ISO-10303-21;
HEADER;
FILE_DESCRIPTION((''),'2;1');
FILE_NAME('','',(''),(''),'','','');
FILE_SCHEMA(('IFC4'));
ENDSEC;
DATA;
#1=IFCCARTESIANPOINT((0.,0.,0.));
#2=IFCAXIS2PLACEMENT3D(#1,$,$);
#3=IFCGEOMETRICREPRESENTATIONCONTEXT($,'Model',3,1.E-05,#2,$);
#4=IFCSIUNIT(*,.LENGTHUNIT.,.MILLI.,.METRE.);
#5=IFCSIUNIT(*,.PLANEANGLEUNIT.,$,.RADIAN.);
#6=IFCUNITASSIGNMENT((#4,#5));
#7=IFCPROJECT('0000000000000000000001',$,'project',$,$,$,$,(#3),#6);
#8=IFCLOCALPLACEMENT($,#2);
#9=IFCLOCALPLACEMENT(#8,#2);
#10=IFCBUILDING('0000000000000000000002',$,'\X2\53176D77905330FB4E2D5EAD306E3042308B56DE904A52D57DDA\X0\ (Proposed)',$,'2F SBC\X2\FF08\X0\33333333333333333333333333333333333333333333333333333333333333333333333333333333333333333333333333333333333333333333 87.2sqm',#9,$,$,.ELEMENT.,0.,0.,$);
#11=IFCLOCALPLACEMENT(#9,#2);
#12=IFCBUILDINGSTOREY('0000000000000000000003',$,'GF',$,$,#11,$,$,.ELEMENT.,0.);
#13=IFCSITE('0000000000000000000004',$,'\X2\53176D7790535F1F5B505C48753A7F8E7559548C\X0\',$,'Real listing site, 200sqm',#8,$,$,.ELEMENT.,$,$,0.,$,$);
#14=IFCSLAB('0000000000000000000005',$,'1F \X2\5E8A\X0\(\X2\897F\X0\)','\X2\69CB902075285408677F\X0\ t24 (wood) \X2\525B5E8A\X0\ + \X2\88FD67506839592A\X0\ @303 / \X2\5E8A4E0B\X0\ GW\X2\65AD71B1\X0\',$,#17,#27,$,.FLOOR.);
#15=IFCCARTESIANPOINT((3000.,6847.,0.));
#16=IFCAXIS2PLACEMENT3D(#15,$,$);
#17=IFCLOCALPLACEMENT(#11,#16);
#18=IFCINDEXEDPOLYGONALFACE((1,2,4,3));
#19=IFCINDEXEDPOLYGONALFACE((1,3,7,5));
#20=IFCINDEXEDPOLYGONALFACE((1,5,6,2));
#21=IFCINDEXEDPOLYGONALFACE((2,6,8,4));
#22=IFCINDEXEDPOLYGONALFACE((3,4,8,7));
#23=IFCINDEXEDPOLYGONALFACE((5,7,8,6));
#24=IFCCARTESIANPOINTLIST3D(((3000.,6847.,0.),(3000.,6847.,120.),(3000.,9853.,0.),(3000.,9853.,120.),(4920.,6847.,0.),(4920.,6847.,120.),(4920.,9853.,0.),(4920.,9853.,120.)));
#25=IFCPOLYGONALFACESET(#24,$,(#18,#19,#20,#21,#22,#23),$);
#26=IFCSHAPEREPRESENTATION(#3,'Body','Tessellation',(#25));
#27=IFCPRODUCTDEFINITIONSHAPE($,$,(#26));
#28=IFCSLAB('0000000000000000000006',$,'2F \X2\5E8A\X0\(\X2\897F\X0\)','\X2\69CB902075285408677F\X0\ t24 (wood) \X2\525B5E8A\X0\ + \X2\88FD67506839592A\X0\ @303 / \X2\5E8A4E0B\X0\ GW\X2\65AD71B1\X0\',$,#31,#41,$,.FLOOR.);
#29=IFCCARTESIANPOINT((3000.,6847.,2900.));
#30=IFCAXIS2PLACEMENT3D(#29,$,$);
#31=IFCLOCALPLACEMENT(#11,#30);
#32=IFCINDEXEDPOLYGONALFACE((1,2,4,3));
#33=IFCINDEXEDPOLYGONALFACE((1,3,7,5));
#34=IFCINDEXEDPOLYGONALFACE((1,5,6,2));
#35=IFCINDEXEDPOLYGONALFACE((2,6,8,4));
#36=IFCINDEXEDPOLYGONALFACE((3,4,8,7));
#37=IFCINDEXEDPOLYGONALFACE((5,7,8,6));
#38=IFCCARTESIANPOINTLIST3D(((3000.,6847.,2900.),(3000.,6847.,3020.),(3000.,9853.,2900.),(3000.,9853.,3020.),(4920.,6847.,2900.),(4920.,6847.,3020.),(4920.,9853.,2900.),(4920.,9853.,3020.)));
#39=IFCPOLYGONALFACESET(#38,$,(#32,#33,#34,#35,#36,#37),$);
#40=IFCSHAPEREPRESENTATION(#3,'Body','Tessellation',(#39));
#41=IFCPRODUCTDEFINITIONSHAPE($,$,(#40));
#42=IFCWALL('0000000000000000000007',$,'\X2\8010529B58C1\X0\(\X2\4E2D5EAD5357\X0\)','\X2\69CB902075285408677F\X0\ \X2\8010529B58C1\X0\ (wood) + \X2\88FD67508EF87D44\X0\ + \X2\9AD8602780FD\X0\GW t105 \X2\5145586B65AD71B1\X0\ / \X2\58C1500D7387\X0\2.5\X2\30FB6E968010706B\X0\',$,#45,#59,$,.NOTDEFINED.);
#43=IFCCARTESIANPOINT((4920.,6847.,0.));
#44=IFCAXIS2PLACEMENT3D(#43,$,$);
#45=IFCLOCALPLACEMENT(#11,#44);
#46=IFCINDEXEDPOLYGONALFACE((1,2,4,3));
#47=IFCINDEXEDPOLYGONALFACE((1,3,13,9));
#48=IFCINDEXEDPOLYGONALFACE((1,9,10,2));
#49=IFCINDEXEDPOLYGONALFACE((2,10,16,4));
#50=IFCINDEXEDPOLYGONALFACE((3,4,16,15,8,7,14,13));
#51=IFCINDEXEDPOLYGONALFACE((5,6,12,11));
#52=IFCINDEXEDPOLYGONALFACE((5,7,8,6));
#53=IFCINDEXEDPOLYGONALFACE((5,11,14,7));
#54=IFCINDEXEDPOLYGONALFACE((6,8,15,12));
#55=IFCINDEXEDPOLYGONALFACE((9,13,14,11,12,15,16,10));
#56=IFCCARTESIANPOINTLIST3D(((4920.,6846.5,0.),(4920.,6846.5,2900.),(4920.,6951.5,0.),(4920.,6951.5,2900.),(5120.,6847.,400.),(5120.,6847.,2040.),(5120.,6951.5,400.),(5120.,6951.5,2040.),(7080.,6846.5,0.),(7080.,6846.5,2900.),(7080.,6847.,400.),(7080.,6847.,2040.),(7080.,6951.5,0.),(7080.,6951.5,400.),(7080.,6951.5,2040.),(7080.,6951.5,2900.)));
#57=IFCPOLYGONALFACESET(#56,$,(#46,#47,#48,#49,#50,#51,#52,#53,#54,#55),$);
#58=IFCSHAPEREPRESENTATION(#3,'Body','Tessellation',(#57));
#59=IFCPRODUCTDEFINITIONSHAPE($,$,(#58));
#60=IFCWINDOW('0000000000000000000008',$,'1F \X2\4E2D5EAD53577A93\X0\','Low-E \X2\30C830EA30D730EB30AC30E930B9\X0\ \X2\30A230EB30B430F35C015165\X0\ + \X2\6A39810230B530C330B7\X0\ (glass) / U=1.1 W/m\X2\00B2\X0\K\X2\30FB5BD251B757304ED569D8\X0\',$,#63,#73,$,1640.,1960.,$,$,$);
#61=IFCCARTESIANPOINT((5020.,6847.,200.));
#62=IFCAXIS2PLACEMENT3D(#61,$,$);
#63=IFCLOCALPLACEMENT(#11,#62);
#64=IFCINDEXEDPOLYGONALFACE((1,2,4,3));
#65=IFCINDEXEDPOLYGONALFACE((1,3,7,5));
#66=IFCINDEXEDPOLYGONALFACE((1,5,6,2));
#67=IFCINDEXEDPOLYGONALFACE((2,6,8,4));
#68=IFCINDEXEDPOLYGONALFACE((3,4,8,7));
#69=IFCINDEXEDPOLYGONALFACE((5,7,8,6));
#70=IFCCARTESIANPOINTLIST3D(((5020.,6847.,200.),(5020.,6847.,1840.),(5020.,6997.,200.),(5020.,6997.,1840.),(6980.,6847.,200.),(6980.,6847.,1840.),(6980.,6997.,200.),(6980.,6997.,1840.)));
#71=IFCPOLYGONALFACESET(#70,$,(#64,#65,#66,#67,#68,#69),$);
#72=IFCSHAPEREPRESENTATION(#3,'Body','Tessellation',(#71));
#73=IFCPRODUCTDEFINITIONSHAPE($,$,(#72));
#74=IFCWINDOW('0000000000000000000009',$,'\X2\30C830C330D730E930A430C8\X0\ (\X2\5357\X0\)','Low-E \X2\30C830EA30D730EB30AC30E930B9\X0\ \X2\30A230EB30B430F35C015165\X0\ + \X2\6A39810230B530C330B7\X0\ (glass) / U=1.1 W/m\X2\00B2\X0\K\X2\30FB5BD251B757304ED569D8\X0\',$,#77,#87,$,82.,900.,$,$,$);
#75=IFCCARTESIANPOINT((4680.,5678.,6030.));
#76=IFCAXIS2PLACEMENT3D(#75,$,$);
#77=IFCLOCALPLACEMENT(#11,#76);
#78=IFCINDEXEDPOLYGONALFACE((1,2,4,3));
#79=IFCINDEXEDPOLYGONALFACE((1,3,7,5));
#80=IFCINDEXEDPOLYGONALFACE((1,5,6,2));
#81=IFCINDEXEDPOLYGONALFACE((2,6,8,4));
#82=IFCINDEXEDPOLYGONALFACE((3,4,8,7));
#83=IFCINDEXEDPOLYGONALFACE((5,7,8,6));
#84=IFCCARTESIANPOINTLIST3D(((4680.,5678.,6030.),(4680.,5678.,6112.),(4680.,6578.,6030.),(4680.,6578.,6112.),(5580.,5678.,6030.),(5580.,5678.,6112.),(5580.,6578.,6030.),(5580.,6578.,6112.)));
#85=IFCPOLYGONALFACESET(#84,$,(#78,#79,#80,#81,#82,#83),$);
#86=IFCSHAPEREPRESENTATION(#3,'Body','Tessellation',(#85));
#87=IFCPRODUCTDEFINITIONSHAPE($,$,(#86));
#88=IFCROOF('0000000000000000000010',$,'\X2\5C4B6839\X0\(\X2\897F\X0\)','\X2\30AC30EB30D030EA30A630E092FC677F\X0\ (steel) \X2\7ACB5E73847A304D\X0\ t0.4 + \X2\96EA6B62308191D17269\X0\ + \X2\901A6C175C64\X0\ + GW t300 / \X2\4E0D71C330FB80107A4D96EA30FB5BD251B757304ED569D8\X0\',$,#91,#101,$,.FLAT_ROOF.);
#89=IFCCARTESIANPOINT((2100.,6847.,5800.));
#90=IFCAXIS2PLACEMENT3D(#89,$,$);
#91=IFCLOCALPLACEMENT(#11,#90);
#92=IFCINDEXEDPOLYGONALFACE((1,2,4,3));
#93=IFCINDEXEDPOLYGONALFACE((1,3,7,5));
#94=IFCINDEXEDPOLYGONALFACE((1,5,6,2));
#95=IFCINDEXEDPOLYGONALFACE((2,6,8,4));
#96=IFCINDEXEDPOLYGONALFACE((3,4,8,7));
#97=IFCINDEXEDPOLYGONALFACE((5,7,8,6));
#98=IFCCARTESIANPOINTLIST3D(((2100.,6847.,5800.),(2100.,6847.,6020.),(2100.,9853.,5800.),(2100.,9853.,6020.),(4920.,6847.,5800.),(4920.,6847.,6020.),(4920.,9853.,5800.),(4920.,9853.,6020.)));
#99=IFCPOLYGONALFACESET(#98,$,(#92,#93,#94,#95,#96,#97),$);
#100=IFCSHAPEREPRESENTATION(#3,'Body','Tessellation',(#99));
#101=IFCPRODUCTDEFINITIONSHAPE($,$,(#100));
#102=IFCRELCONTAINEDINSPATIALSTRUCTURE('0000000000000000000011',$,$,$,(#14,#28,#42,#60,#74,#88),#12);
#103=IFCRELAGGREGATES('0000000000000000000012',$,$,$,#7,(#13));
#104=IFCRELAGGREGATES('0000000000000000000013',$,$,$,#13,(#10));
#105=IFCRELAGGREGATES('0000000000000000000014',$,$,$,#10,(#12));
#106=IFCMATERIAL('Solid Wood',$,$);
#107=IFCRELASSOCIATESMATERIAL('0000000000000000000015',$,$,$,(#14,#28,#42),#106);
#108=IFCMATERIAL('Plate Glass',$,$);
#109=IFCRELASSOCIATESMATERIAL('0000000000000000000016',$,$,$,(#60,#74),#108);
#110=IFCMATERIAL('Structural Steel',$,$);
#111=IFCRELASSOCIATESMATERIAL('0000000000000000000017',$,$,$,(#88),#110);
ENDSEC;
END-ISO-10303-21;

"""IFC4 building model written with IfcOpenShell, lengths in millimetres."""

from ifc_helpers import new_model, si_unit, frame, frame_2d, origin, place, context, project, spatial, rectangle, extrude, material, element, fill, save


model = new_model("IFC4")

# Units and contexts
model_context = context("Model", 3, precision=1e-05, world=origin())
ifc_project = project(units=[si_unit("LENGTHUNIT", "METRE", prefix="MILLI"), si_unit("PLANEANGLEUNIT", "RADIAN")], contexts=[model_context])

# Site, building, storey
site_placement = place(None, origin())
site = spatial("IfcSite", under=ifc_project, at=site_placement, Name="北海道弟子屈町美留和", ObjectType="Real listing site, 200sqm", CompositionType="ELEMENT", RefElevation=0.0)
building_placement = place(site_placement, origin())
building = spatial("IfcBuilding", under=site, at=building_placement, Name="北海道・中庭のある回遊動線 (Proposed)", ObjectType="2F SBC（33333333333333333333333333333333333333333333333333333333333333333333333333333333333333333333333333333333333333333333 87.2sqm", CompositionType="ELEMENT", ElevationOfRefHeight=0.0, ElevationOfTerrain=0.0)
storey_placement = place(building_placement, origin())
storey = spatial("IfcBuildingStorey", under=building, at=storey_placement, Name="GF", CompositionType="ELEMENT", Elevation=0.0)

# Shared definitions
ifc_material_1 = material(Name="Solid Wood")

# Slabs
slab_1_placement = place(storey_placement, frame((3000.0, 6847.0, 0.0)))
element("IfcSlab", 1, at=slab_1_placement, inside=storey, material=ifc_material_1, Name="1F 床(西)", Description="構造用合板 t24 (wood) 剛床 + 製材根太 @303 / 床下 GW断熱", PredefinedType="FLOOR", context=model_context, shape_type="SweptSolid", body=[
    extrude(rectangle(XDim=1920.0, YDim=3006.0, at=frame_2d((960.0, 1503.0))), frame((3000.0, 6847.0, 0.0)), (0.0, 0.0, 1.0), 120.0),
])
slab_2_placement = place(storey_placement, frame((3000.0, 6847.0, 2900.0)))
element("IfcSlab", 2, at=slab_2_placement, inside=storey, material=ifc_material_1, Name="2F 床(西)", Description="構造用合板 t24 (wood) 剛床 + 製材根太 @303 / 床下 GW断熱", PredefinedType="FLOOR", context=model_context, shape_type="SweptSolid", body=[
    extrude(rectangle(XDim=1920.0, YDim=3006.0, at=frame_2d((960.0, 1503.0))), frame((3000.0, 6847.0, 2900.0)), (0.0, 0.0, 1.0), 120.0),
])

# Wall, opening, window
wall_placement = place(storey_placement, frame((4920.0, 6847.0, 0.0)))
wall = element("IfcWall", 3, at=wall_placement, inside=storey, material=ifc_material_1, Name="耐力壁(中庭南)", Description="構造用合板 耐力壁 (wood) + 製材軸組 + 高性能GW t105 充填断熱 / 壁倍率2.5・準耐火", PredefinedType="NOTDEFINED", context=model_context, shape_type="SweptSolid", body=[
    extrude(rectangle(XDim=2160.0, YDim=105.0, at=frame_2d((1080.0, 52.0))), frame((4920.0, 6847.0, 0.0)), (0.0, 0.0, 1.0), 2900.0),
])
opening_placement = place(storey_placement, frame((5020.0, 6847.0, 200.0)))
opening = element("IfcOpeningElement", 4, at=opening_placement, cuts=wall, PredefinedType="NOTDEFINED", context=model_context, shape_type="SweptSolid", body=[
    extrude(rectangle(XDim=1960.0, YDim=150.0, at=frame_2d((980.0, 75.0))), frame((5020.0, 6847.0, 200.0)), (0.0, 0.0, 1.0), 1640.0),
])
ifc_material_2 = material(Name="Plate Glass")
window_1_placement = place(storey_placement, frame((5020.0, 6847.0, 200.0)))
window_1 = element("IfcWindow", 5, at=window_1_placement, inside=storey, material=ifc_material_2, Name="1F 中庭南窓", Description="Low-E トリプルガラス アルゴン封入 + 樹脂サッシ (glass) / U=1.1 W/m²K・寒冷地仕様", OverallHeight=1640.0, OverallWidth=1960.0, context=model_context, shape_type="SweptSolid", body=[
    extrude(rectangle(XDim=1960.0, YDim=150.0, at=frame_2d((980.0, 75.0))), frame((5020.0, 6847.0, 200.0)), (0.0, 0.0, 1.0), 1640.0),
])
fill(opening, window_1)

# Window
window_2_placement = place(storey_placement, frame((4680.0, 5678.0, 6030.0)))
element("IfcWindow", 6, at=window_2_placement, inside=storey, material=ifc_material_2, Name="トップライト (南)", Description="Low-E トリプルガラス アルゴン封入 + 樹脂サッシ (glass) / U=1.1 W/m²K・寒冷地仕様", OverallHeight=82.0, OverallWidth=900.0, context=model_context, shape_type="SweptSolid", body=[
    extrude(rectangle(XDim=900.0, YDim=900.0, at=frame_2d((450.0, 450.0))), frame((4680.0, 5678.0, 6030.0)), (0.0, 0.0, 1.0), 82.0),
])

# Roof
ifc_material_3 = material(Name="Structural Steel")
for number, where, name in (
    (7, (2100.0, 6847.0, 5800.0), "屋根(西)"),
):
    element("IfcRoof", number, at=place(storey_placement, frame(where)), inside=storey, material=ifc_material_3, Name=name, Description="ガルバリウム鋼板 (steel) 立平葺き t0.4 + 雪止め金物 + 通気層 + GW t300 / 不燃・耐積雪・寒冷地仕様", PredefinedType="FLAT_ROOF", context=model_context, shape_type="SweptSolid", body=[
        extrude(rectangle(XDim=2820.0, YDim=3006.0, at=frame_2d((1410.0, 1503.0))), frame((2100.0, 6847.0, 5800.0)), (0.0, 0.0, 1.0), 220.0),
    ])

save(model, "model.ifc")
